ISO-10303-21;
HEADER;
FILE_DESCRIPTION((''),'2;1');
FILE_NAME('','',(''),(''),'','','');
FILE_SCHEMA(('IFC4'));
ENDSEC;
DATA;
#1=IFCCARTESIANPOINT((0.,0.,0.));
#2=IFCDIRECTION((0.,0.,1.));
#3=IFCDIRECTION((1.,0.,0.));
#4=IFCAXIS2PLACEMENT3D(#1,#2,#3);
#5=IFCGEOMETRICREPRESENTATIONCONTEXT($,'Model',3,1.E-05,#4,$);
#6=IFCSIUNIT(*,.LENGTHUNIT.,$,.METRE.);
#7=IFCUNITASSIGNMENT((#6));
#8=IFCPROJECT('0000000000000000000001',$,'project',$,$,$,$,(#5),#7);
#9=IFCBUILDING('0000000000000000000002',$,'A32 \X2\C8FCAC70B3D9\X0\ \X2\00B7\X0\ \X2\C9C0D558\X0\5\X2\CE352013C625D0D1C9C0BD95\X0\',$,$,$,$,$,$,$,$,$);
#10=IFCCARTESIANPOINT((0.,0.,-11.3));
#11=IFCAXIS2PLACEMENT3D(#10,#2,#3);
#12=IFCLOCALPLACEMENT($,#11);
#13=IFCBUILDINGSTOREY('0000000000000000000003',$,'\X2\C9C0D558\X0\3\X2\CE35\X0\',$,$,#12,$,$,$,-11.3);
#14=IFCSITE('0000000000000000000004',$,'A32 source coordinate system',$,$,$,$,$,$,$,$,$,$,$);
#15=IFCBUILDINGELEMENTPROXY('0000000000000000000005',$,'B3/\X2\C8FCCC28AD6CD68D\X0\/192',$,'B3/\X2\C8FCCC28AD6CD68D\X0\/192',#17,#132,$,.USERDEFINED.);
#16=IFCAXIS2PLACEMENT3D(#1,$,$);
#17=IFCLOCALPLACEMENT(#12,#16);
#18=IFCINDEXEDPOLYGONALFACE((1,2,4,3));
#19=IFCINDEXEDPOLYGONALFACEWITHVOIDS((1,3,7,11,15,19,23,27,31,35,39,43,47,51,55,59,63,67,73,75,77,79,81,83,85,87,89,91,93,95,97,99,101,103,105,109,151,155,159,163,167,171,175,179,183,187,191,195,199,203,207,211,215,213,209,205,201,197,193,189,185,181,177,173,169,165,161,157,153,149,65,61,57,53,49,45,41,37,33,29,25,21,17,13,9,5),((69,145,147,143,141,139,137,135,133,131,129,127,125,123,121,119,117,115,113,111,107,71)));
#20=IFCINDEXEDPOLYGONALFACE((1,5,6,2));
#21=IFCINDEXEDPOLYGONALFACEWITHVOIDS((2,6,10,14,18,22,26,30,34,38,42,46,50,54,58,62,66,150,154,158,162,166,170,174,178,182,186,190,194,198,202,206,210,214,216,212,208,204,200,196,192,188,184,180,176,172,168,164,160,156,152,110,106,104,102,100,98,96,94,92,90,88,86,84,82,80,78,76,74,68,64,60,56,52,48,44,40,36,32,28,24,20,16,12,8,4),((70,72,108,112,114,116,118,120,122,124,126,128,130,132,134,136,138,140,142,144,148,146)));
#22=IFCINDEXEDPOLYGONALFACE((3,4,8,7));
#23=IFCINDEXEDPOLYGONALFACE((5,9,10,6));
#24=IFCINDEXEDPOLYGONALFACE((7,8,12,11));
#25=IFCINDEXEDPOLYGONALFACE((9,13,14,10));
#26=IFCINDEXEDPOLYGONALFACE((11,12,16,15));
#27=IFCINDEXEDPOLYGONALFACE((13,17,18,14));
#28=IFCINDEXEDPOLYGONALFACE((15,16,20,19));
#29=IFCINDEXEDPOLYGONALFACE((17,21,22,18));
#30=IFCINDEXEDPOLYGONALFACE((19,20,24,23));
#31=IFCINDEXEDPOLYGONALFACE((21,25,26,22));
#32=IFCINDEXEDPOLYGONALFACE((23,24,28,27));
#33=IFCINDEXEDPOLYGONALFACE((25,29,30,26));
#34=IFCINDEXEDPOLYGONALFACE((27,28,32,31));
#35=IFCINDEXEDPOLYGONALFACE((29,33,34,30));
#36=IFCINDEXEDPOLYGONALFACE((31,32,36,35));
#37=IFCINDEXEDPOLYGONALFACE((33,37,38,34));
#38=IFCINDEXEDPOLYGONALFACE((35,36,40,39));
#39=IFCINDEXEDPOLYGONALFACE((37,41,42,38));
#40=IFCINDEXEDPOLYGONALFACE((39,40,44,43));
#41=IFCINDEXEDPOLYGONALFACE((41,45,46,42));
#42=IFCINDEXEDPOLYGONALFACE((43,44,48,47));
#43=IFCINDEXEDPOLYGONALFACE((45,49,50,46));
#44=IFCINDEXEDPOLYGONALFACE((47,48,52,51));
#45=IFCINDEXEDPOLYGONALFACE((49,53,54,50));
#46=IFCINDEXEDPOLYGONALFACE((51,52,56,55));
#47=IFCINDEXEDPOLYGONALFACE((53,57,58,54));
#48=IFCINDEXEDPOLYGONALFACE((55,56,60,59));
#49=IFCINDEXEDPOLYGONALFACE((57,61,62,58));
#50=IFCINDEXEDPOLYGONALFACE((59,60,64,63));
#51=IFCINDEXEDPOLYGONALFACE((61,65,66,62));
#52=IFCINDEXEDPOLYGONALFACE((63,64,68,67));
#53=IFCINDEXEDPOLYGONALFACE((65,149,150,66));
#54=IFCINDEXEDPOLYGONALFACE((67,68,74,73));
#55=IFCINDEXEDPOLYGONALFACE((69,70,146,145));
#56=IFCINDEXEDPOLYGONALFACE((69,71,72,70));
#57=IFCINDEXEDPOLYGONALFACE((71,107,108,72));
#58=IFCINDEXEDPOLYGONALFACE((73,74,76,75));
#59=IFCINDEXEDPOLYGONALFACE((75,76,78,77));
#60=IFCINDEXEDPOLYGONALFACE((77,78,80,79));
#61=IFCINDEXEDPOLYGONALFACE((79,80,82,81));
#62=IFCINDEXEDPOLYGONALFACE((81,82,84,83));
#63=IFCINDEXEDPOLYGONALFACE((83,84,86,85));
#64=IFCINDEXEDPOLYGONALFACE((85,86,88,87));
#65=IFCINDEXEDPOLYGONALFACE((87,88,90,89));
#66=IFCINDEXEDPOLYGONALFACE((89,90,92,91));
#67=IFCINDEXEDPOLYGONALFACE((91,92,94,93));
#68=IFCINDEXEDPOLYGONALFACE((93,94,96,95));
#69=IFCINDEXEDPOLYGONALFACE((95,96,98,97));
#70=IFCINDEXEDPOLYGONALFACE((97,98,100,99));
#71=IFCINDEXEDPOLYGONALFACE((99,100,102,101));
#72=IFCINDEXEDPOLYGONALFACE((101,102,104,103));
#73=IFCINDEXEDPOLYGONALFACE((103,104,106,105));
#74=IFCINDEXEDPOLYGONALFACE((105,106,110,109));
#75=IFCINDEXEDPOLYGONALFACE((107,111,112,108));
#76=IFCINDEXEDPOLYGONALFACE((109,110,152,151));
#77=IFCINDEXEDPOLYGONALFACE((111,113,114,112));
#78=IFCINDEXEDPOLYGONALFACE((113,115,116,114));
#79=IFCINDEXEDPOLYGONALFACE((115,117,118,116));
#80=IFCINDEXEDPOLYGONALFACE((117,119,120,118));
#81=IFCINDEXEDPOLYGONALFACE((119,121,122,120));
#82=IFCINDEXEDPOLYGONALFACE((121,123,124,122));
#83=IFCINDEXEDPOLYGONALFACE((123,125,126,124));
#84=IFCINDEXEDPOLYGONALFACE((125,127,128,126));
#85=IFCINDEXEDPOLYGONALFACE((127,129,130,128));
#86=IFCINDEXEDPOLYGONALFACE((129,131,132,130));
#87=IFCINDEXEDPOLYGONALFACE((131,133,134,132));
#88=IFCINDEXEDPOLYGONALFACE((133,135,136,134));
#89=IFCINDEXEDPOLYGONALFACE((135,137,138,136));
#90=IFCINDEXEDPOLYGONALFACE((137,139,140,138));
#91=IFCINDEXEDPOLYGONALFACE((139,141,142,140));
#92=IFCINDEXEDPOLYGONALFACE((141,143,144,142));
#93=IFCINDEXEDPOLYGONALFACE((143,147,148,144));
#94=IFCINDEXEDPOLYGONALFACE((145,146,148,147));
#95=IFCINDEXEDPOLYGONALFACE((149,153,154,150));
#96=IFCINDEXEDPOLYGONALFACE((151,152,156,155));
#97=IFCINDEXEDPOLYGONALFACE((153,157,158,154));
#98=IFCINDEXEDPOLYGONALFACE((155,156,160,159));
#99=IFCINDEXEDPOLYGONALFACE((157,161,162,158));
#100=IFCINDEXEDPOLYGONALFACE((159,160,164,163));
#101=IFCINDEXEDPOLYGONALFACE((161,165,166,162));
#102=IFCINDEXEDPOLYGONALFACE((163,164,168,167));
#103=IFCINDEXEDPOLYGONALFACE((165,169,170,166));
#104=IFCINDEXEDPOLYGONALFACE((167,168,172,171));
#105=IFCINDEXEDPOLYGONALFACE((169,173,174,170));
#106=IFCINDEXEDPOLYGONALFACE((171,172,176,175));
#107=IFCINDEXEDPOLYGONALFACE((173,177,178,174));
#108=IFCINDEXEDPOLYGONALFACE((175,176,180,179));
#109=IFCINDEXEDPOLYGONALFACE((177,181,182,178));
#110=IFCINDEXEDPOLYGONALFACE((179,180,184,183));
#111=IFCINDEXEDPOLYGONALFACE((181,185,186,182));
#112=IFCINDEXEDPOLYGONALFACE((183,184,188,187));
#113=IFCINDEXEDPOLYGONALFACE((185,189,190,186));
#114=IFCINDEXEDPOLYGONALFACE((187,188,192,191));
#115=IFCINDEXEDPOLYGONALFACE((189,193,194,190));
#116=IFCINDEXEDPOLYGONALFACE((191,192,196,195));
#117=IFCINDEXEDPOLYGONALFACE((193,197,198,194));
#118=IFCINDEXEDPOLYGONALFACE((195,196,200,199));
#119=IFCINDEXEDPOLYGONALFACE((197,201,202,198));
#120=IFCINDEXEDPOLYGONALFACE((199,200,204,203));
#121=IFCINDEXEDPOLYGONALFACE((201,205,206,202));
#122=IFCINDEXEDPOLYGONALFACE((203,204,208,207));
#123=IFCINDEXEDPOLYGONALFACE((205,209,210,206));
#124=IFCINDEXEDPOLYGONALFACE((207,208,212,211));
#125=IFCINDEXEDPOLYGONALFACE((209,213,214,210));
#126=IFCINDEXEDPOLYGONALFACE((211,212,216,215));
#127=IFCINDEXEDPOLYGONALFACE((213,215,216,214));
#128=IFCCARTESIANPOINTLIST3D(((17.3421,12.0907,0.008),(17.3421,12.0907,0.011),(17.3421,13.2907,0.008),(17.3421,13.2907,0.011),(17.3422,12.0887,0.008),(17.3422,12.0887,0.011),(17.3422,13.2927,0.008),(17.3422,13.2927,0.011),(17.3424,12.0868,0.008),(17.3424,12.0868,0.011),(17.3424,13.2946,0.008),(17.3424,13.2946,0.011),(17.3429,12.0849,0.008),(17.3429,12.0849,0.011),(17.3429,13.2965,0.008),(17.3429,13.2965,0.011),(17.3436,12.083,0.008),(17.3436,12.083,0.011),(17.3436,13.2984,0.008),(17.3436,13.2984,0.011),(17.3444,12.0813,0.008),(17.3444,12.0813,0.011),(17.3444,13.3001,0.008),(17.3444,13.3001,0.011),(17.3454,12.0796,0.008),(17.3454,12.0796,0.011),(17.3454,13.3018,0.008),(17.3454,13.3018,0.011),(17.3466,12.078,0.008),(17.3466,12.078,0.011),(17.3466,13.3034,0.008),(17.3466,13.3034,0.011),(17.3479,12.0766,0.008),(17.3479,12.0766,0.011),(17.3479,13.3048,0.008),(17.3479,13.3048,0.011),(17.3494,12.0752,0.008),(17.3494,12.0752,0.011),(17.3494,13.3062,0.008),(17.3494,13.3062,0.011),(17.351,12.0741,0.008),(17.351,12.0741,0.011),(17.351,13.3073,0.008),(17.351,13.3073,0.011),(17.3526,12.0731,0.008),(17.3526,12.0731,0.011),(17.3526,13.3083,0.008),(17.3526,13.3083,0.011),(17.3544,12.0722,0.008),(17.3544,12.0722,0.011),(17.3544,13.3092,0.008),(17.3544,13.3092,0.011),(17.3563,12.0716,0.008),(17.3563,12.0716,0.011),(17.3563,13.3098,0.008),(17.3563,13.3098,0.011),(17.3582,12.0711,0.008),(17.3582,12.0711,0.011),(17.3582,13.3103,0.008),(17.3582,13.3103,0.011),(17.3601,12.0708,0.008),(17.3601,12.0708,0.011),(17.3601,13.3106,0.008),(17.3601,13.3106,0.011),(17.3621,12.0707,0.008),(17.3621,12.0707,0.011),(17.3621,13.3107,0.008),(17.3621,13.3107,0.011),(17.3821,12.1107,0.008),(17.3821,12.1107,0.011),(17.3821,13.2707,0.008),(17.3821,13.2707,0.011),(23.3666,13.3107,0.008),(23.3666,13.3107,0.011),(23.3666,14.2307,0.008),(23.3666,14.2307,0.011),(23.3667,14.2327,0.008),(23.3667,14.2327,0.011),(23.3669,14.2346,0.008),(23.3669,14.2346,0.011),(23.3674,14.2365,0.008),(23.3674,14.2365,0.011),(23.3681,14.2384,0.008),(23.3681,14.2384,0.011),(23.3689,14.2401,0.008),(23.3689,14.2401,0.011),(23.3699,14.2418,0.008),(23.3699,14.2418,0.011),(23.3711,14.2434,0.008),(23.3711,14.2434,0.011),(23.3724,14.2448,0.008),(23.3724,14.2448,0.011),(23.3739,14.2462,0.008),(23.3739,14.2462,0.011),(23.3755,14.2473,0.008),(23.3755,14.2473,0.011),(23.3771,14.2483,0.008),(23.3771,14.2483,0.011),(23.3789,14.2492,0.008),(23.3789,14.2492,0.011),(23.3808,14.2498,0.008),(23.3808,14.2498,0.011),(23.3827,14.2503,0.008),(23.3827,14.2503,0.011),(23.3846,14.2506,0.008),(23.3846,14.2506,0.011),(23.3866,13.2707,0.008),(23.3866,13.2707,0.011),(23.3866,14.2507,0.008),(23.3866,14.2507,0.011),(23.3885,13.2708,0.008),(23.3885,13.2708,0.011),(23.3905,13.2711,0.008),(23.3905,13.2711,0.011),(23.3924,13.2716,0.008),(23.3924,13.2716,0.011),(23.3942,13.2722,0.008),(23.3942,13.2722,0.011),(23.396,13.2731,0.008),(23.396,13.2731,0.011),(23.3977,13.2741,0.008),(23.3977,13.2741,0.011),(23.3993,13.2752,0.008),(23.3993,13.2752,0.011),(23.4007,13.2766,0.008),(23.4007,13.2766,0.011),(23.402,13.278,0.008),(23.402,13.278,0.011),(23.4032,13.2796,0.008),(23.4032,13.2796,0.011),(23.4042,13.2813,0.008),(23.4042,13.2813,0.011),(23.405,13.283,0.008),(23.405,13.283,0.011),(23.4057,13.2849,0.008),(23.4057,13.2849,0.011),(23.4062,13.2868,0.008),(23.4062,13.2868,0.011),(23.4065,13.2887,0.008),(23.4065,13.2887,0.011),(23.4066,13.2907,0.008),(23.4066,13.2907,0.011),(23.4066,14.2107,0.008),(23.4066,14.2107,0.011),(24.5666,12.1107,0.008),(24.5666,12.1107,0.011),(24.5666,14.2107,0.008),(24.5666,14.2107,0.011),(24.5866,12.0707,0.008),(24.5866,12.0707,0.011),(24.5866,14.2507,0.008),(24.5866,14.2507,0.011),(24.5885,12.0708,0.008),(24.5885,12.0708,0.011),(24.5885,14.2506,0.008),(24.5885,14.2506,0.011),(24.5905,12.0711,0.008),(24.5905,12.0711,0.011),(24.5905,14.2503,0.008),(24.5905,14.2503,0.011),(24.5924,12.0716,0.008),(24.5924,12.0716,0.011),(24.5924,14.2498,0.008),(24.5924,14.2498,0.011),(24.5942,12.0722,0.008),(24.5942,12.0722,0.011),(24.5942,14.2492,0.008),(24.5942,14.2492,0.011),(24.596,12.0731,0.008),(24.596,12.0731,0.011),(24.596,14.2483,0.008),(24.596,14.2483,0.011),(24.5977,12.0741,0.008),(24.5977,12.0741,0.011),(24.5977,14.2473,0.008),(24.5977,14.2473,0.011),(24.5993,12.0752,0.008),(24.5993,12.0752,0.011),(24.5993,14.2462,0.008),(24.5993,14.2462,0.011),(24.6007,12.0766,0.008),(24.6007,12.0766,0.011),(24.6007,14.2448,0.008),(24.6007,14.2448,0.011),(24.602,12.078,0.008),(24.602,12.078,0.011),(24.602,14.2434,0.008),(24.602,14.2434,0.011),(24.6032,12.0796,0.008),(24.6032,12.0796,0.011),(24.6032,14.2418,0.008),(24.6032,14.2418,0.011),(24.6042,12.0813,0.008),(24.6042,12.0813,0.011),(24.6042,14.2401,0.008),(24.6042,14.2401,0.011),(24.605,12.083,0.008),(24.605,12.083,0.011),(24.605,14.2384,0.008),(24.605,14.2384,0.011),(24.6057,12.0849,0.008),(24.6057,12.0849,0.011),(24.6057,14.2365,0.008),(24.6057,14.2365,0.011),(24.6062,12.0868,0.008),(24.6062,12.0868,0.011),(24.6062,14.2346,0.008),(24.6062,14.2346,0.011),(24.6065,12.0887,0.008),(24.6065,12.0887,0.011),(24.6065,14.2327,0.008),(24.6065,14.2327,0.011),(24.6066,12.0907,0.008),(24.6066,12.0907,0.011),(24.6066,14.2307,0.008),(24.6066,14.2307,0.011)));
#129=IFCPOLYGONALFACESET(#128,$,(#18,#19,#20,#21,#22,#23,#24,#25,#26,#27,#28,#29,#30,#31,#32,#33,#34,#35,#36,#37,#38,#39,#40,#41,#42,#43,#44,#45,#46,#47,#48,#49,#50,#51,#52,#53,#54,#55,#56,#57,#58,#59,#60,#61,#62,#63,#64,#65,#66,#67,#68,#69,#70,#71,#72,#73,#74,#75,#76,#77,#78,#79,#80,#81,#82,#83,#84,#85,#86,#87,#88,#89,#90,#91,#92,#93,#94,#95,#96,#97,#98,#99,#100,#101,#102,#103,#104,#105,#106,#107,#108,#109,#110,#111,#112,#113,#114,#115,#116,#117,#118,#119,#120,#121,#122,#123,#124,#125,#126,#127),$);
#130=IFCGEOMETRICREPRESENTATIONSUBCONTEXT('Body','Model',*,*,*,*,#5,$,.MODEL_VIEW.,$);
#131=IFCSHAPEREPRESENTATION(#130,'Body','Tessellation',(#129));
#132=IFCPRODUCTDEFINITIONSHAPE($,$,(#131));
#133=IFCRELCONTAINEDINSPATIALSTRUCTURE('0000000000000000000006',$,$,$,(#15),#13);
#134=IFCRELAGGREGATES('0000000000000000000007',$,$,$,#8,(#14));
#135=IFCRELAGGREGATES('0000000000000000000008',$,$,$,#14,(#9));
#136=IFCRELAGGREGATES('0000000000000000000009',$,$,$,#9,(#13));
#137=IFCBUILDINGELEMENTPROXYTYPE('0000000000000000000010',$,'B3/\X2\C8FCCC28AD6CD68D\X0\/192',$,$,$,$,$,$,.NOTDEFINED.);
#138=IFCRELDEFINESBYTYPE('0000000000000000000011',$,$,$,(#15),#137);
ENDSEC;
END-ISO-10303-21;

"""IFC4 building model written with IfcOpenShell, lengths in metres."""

from ifc_helpers import new_model, si_unit, frame, origin, origin_with_axes, place, context, subcontext, project, spatial, polyline, outline, extrude, source, transform, mapped, type_object, type_shapes, element, save


model = new_model("IFC4")

# Units and contexts
model_context = context("Model", 3, precision=1e-05, world=origin_with_axes())
body_context = subcontext(model_context, "Body", "Model", "MODEL_VIEW")
ifc_project = project(units=[si_unit("LENGTHUNIT", "METRE")], contexts=[model_context])

# Site, building, storey
site = spatial("IfcSite", under=ifc_project, Name="A32 source coordinate system")
building = spatial("IfcBuilding", under=site, Name="A32 주거동 · 지하5층–옥탑지붕")
storey_placement = place(None, frame((0.0, 0.0, -11.3), z_axis=(0.0, 0.0, 1.0), x_axis=(1.0, 0.0, 0.0)))
storey = spatial("IfcBuildingStorey", under=building, at=storey_placement, Name="지하3층", Elevation=-11.3)

# Building element proxy
building_element_proxy_type_1 = type_object("IfcBuildingElementProxyType", Name="B3/주차구획/192", PredefinedType="NOTDEFINED")
shared_shape_1 = source(origin(), body_context, "Body", "SweptSolid", [
    extrude(outline(polyline([(24.5866, 14.2507), (24.5885, 14.2506), (24.5905, 14.2503), (24.5924, 14.2498), (24.5942, 14.2492), (24.596, 14.2483), (24.5977, 14.2473), (24.5993, 14.2462), (24.6007, 14.2448), (24.602, 14.2434), (24.6032, 14.2418), (24.6042, 14.2401), (24.605, 14.2384), (24.6057, 14.2365), (24.6062, 14.2346), (24.6065, 14.2327), (24.6066, 14.2307), (24.6066, 12.0907), (24.6065, 12.0887), (24.6062, 12.0868), (24.6057, 12.0849), (24.605, 12.083), (24.6042, 12.0813), (24.6032, 12.0796), (24.602, 12.078), (24.6007, 12.0766), (24.5993, 12.0752), (24.5977, 12.0741), (24.596, 12.0731), (24.5942, 12.0722), (24.5924, 12.0716), (24.5905, 12.0711), (24.5885, 12.0708), (24.5866, 12.0707), (17.3621, 12.0707), (17.3601, 12.0708), (17.3582, 12.0711), (17.3563, 12.0716), (17.3544, 12.0722), (17.3526, 12.0731), (17.351, 12.0741), (17.3494, 12.0752), (17.3479, 12.0766), (17.3466, 12.078), (17.3454, 12.0796), (17.3444, 12.0813), (17.3436, 12.083), (17.3429, 12.0849), (17.3424, 12.0868), (17.3422, 12.0887), (17.3421, 12.0907), (17.3421, 13.2907), (17.3422, 13.2927), (17.3424, 13.2946), (17.3429, 13.2965), (17.3436, 13.2984), (17.3444, 13.3001), (17.3454, 13.3018), (17.3466, 13.3034), (17.3479, 13.3048), (17.3494, 13.3062), (17.351, 13.3073), (17.3526, 13.3083), (17.3544, 13.3092), (17.3563, 13.3098), (17.3582, 13.3103), (17.3601, 13.3106), (17.3621, 13.3107), (23.3666, 13.3107), (23.3666, 14.2307), (23.3667, 14.2327), (23.3669, 14.2346), (23.3674, 14.2365), (23.3681, 14.2384), (23.3689, 14.2401), (23.3699, 14.2418), (23.3711, 14.2434), (23.3724, 14.2448), (23.3739, 14.2462), (23.3755, 14.2473), (23.3771, 14.2483), (23.3789, 14.2492), (23.3808, 14.2498), (23.3827, 14.2503), (23.3846, 14.2506), (23.3866, 14.2507), (24.5866, 14.2507)]), holes=[polyline([(24.5666, 14.2107), (23.4066, 14.2107), (23.4066, 13.2907), (23.4065, 13.2887), (23.4062, 13.2868), (23.4057, 13.2849), (23.405, 13.283), (23.4042, 13.2813), (23.4032, 13.2796), (23.402, 13.278), (23.4007, 13.2766), (23.3993, 13.2752), (23.3977, 13.2741), (23.396, 13.2731), (23.3942, 13.2722), (23.3924, 13.2716), (23.3905, 13.2711), (23.3885, 13.2708), (23.3866, 13.2707), (17.3821, 13.2707), (17.3821, 12.1107), (24.5666, 12.1107), (24.5666, 14.2107)])]), frame((0.0, 0.0, 0.008)), (0.0, 0.0, 1.0), 0.003),
])
type_shapes(building_element_proxy_type_1, [shared_shape_1])
proxy_1_placement = place(storey_placement, origin_with_axes())
element("IfcBuildingElementProxy", 1, at=proxy_1_placement, inside=storey, type_object=building_element_proxy_type_1, Name="B3/주차구획/192", ObjectType="B3/주차구획/192", PredefinedType="USERDEFINED", context=body_context, shape_type="MappedRepresentation", body=[
    mapped(shared_shape_1, transform((0.0, 0.0, 0.0), scale=1.0)),
])

save(model, "model.ifc")
